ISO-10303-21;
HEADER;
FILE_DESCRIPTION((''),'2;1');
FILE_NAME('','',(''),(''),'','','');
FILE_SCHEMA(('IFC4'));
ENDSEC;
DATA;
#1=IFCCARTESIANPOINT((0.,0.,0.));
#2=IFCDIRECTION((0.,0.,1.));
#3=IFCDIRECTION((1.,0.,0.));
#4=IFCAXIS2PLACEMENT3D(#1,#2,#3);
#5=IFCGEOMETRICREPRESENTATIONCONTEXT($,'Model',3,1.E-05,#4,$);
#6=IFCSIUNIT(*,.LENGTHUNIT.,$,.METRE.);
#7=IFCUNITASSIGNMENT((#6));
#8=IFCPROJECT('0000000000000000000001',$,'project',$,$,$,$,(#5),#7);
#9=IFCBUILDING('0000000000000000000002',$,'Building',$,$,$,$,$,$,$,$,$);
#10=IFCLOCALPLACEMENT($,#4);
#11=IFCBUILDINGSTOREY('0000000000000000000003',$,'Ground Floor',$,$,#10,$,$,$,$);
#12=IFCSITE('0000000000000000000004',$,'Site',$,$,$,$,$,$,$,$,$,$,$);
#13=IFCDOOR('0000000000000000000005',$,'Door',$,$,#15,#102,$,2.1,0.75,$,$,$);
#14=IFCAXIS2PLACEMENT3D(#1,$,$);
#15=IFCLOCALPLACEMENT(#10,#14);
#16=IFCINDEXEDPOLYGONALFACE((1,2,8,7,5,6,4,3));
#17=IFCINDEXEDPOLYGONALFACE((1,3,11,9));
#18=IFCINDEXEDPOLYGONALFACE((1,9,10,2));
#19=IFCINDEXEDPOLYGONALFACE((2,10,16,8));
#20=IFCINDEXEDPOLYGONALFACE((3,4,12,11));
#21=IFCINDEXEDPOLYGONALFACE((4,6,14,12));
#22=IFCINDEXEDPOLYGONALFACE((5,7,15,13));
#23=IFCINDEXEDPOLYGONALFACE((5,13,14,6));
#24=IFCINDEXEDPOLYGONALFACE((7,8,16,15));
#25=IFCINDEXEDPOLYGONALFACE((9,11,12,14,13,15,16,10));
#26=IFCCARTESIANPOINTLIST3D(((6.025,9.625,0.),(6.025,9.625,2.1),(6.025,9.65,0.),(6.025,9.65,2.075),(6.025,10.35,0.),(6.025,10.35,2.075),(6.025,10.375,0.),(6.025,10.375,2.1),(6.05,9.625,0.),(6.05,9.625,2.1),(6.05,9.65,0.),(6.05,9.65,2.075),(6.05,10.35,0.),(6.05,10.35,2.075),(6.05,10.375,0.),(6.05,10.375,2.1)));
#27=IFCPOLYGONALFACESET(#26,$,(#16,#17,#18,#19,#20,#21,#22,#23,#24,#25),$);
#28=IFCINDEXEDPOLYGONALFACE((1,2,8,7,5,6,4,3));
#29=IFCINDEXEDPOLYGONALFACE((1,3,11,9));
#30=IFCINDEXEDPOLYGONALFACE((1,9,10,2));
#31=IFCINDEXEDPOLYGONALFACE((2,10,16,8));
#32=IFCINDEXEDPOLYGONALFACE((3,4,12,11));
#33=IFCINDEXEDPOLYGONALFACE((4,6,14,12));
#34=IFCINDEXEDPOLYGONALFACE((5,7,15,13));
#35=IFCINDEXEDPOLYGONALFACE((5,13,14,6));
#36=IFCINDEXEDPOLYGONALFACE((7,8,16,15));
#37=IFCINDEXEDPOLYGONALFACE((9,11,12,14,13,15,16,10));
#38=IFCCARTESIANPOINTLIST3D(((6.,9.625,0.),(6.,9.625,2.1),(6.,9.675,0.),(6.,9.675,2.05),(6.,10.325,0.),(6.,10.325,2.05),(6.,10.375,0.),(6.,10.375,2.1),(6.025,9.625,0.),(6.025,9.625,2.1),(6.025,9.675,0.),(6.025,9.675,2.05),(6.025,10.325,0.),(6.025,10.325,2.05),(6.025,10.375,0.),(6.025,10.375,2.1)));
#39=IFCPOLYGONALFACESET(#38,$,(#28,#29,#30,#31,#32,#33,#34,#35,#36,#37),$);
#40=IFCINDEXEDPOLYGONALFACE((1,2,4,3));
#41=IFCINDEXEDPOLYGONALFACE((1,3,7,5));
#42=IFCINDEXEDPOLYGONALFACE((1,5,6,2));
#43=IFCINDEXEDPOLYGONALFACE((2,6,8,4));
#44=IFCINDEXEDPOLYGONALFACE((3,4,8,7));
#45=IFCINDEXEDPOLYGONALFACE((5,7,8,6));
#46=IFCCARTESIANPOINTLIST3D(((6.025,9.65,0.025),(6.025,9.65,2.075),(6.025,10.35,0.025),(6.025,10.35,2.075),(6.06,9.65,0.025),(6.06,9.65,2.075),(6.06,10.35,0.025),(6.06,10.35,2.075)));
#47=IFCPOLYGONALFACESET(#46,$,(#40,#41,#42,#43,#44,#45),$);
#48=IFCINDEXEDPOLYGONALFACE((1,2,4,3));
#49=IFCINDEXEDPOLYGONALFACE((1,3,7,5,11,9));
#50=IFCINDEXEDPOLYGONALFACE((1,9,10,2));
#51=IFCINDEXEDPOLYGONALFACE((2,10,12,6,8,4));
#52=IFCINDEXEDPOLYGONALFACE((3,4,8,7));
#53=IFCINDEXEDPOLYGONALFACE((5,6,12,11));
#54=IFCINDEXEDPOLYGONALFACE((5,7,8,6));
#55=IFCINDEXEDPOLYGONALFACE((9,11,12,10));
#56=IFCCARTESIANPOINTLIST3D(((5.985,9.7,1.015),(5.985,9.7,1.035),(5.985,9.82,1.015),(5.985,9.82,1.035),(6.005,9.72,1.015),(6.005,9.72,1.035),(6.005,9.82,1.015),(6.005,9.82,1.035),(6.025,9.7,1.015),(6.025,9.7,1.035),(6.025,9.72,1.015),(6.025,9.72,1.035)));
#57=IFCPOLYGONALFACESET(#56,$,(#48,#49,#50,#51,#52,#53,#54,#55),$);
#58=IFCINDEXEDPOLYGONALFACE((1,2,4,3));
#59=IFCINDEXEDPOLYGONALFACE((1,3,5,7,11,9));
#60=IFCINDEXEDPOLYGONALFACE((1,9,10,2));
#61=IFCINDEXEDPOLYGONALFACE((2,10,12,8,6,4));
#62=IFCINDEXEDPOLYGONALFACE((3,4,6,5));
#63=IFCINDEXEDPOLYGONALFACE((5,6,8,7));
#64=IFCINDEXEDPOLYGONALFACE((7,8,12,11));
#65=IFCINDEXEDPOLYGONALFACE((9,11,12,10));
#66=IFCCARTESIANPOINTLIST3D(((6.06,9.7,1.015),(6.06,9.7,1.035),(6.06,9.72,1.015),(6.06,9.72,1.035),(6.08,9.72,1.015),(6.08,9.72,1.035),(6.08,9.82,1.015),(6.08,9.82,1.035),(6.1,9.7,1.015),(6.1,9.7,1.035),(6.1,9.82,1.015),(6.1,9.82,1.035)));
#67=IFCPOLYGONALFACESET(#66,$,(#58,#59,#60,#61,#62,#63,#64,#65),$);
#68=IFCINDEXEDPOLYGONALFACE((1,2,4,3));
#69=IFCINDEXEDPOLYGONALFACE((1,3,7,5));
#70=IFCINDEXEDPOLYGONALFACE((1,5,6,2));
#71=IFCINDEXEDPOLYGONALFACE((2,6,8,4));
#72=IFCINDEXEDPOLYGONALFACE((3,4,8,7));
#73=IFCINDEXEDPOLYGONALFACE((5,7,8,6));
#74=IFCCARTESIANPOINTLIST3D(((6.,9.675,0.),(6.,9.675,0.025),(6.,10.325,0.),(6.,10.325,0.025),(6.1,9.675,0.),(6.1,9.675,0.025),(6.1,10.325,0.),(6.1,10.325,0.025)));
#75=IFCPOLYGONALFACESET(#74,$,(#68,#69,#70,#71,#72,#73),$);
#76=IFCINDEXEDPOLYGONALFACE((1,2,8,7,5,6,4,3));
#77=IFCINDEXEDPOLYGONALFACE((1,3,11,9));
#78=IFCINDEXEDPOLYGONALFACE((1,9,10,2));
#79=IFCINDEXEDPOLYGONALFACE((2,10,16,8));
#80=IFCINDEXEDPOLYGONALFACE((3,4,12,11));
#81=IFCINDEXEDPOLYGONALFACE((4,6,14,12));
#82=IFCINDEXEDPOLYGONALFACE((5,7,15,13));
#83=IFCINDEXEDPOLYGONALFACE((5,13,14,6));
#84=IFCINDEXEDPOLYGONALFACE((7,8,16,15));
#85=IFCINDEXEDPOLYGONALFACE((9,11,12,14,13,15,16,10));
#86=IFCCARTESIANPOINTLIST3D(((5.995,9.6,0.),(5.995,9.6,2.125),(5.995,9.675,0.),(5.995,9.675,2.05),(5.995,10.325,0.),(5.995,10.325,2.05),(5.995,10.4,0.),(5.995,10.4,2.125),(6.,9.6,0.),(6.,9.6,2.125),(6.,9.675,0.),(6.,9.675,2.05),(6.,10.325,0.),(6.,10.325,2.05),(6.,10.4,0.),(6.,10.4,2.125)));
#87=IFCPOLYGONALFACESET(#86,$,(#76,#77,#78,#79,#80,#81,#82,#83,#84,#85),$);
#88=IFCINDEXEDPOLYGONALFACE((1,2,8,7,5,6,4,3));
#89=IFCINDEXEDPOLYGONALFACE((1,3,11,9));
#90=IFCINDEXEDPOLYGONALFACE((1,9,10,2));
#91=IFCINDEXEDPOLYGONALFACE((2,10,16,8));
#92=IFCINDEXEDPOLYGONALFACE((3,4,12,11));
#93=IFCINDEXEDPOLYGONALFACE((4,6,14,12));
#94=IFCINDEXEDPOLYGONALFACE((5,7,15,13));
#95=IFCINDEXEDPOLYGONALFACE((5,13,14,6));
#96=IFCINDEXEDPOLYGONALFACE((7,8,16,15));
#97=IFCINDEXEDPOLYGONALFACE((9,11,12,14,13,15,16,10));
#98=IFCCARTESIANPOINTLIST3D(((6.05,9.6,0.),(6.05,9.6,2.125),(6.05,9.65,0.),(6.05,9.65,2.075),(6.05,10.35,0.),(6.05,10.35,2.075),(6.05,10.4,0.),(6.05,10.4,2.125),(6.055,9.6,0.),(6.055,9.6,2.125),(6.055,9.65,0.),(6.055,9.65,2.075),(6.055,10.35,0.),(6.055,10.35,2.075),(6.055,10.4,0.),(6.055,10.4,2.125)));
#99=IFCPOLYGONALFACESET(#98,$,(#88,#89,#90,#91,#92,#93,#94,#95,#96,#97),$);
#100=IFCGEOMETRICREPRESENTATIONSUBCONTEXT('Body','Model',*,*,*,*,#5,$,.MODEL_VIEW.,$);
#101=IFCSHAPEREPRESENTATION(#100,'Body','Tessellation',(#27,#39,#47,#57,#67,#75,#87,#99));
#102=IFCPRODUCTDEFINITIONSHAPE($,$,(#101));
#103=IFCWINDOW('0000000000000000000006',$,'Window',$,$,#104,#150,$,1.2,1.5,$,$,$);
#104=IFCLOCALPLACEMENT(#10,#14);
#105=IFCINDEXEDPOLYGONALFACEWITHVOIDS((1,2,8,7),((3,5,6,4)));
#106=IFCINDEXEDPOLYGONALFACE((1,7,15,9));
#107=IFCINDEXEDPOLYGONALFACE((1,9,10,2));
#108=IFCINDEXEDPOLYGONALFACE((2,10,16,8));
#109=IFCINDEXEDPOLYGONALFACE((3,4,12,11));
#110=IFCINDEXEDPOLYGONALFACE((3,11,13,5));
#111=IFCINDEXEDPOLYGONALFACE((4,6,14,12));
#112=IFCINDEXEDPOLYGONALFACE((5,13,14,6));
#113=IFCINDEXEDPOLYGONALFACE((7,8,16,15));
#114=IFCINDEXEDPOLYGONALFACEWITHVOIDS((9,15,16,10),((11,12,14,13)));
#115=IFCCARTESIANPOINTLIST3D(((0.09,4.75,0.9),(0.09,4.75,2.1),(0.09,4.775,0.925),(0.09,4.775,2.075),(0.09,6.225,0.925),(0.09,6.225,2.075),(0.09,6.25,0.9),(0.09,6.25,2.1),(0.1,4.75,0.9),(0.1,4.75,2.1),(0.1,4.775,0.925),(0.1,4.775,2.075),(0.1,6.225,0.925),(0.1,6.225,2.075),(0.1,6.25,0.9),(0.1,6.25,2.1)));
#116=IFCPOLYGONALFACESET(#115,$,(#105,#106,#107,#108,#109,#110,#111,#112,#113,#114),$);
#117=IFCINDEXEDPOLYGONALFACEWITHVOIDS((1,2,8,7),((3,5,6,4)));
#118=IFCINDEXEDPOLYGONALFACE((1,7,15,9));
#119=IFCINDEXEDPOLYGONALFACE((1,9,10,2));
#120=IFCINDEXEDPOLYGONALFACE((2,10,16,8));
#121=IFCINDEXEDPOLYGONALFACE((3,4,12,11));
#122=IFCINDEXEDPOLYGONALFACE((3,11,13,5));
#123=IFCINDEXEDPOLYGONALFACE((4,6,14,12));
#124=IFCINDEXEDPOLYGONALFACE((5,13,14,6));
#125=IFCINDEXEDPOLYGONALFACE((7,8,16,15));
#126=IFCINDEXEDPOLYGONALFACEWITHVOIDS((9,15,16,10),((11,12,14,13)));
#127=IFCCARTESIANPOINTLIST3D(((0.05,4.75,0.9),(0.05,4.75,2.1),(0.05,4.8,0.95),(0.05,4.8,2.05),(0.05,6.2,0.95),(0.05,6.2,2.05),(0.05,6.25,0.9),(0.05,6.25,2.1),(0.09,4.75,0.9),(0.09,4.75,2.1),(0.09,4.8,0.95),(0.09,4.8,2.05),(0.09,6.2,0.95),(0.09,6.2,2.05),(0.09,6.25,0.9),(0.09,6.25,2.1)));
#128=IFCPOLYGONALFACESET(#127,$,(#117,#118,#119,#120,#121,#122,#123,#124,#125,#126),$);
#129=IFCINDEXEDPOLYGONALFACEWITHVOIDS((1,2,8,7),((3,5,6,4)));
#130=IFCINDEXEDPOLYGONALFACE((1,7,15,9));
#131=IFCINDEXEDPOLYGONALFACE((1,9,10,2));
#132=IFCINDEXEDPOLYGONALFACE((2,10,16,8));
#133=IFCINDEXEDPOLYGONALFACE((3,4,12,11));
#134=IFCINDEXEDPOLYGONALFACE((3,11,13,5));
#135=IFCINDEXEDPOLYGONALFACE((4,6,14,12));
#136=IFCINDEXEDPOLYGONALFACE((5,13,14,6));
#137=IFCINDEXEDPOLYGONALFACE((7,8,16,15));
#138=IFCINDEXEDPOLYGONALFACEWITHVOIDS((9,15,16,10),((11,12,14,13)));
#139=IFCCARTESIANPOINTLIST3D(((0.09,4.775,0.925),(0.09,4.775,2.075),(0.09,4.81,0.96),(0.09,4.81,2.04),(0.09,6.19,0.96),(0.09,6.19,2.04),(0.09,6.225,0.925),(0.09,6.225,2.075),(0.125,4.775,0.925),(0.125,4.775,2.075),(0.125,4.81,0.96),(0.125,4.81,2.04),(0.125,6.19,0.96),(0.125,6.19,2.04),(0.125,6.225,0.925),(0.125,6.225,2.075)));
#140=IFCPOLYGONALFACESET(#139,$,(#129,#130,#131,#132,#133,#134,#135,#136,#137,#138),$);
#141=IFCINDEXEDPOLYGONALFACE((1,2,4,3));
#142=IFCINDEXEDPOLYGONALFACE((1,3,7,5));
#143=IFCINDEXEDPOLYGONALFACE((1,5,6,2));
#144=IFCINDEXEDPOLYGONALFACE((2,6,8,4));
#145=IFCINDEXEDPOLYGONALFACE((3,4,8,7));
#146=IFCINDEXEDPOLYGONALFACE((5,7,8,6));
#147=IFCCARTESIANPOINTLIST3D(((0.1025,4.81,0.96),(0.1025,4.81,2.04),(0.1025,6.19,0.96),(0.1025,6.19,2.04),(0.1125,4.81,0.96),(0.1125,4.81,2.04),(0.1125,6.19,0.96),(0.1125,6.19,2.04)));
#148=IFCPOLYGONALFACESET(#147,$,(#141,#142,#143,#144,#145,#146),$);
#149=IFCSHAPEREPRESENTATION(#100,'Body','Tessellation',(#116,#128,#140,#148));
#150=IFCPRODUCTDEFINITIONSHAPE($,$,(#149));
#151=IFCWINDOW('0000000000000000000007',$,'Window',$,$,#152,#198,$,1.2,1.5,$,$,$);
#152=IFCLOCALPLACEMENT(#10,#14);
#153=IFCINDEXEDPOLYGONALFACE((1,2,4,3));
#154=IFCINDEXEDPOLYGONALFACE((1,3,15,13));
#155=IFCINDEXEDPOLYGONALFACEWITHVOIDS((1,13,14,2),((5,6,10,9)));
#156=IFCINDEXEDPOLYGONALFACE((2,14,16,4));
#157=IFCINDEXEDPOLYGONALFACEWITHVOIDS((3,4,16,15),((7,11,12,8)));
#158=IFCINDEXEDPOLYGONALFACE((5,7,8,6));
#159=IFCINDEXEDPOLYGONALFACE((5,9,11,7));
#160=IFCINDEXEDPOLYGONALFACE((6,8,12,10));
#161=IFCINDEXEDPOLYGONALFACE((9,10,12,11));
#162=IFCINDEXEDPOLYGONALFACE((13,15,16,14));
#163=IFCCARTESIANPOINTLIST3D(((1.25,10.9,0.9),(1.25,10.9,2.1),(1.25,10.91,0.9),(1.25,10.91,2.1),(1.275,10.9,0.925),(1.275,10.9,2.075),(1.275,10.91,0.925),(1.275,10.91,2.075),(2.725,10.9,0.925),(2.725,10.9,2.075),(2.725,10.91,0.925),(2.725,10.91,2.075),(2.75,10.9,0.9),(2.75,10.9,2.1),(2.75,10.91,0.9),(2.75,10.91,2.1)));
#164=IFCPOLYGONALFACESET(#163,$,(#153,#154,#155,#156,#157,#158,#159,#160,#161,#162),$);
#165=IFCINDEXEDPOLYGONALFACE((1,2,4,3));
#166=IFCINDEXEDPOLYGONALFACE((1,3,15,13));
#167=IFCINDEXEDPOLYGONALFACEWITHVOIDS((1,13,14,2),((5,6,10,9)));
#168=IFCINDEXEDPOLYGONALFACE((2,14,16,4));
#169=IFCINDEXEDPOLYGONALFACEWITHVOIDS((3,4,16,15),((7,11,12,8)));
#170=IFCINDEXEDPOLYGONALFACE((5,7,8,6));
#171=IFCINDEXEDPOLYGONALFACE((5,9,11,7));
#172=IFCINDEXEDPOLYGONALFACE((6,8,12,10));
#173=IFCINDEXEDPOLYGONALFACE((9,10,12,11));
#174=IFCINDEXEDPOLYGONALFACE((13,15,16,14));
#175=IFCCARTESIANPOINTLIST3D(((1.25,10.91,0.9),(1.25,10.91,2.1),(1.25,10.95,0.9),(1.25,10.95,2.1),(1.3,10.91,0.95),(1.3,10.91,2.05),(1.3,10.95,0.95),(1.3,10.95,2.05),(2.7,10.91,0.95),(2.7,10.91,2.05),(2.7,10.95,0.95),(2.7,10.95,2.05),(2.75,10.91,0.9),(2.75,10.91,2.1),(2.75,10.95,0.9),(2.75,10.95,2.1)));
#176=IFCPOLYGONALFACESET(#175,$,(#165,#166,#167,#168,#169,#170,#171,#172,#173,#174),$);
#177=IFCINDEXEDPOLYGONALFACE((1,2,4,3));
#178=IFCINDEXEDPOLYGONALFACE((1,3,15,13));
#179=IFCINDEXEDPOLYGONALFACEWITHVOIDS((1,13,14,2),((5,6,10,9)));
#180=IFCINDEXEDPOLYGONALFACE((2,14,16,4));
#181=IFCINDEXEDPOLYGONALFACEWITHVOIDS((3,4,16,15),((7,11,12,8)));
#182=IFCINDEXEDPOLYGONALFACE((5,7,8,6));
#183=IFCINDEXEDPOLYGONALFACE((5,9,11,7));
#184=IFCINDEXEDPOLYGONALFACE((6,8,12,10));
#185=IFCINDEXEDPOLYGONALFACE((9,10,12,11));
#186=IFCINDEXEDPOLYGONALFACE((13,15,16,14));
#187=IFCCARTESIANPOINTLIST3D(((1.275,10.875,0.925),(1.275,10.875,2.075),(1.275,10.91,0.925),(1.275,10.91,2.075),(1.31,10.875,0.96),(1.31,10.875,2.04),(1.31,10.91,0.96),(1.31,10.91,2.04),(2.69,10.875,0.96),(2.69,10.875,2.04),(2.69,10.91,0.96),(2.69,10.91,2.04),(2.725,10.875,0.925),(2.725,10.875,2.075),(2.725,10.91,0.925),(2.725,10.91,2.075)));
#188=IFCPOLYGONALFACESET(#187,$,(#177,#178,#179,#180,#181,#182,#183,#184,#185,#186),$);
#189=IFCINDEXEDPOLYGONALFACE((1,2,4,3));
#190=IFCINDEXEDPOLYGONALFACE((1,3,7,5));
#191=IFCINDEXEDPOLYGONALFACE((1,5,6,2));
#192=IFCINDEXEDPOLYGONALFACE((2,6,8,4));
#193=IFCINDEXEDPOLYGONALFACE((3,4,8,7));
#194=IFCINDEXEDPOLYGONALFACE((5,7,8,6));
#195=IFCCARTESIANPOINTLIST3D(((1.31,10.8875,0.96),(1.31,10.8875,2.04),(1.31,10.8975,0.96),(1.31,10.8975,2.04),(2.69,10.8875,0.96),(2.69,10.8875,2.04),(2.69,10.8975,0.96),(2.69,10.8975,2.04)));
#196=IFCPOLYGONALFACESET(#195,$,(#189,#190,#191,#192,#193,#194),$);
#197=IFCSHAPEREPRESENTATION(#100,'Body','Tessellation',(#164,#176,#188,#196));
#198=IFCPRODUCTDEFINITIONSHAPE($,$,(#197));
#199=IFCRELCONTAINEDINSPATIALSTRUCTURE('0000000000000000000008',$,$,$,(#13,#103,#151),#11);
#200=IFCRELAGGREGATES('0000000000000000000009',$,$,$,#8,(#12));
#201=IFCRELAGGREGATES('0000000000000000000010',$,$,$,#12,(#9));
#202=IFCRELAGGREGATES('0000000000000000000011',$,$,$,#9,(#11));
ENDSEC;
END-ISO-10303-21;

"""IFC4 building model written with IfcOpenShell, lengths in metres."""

from ifc_helpers import new_model, si_unit, frame, origin_with_axes, place, context, subcontext, project, spatial, line, indexed_curve, outline, extrude, element, save


model = new_model("IFC4")

# Units and contexts
model_context = context("Model", 3, precision=1e-05, world=origin_with_axes())
body_context = subcontext(model_context, "Body", "Model", "MODEL_VIEW")
ifc_project = project(units=[si_unit("LENGTHUNIT", "METRE")], contexts=[model_context])

# Site, building, storey
site = spatial("IfcSite", under=ifc_project, Name="Site")
building = spatial("IfcBuilding", under=site, Name="Building")
storey_placement = place(None, origin_with_axes())
storey = spatial("IfcBuildingStorey", under=building, at=storey_placement, Name="Ground Floor")

# Door
door_1_placement = place(storey_placement, frame((6.0, 10.375, 0.0), z_axis=(0.0, 0.0, 1.0), x_axis=(0.0, -1.0, 0.0)))
element("IfcDoor", 1, at=door_1_placement, inside=storey, Name="Door", OverallHeight=2.1, OverallWidth=0.75, context=body_context, shape_type="SweptSolid", body=[
    extrude(outline(indexed_curve([(0.0, 0.0), (0.0, 2.1), (0.75, 2.1), (0.75, 0.0), (0.725, 0.0), (0.725, 2.075), (0.025, 2.075), (0.025, 0.0)], segments=[line(1, 2, 3, 4, 5, 6, 7, 8, 1)])), frame((0.0, 0.025, 0.0), z_axis=(0.0, -1.0, 0.0), x_axis=(1.0, 0.0, 0.0)), (0.0, 0.0, -1.0), 0.025),
    extrude(outline(indexed_curve([(0.0, 0.0), (0.0, 2.1), (0.75, 2.1), (0.75, 0.0), (0.7, 0.0), (0.7, 2.05), (0.05, 2.05), (0.05, 0.0)], segments=[line(1, 2, 3, 4, 5, 6, 7, 8, 1)])), frame((0.0, 0.0, 0.0), z_axis=(0.0, -1.0, 0.0), x_axis=(1.0, 0.0, 0.0)), (0.0, 0.0, -1.0), 0.025),
    extrude(outline(indexed_curve([(0.0, 0.0), (0.7, 0.0), (0.7, 0.035), (0.0, 0.035)], segments=[line(1, 2, 3, 4, 1)])), frame((0.025, 0.025, 0.025), z_axis=(0.0, 0.0, 1.0), x_axis=(1.0, 0.0, 0.0)), (0.0, 0.0, 1.0), 2.05),
    extrude(outline(indexed_curve([(0.0, 0.0), (0.0, -0.04), (-0.12, -0.04), (-0.12, -0.02), (-0.02, -0.02), (-0.02, 0.0)], segments=[line(1, 2, 3, 4, 5, 6, 1)])), frame((0.675, 0.025, 1.015), z_axis=(0.0, 0.0, 1.0), x_axis=(1.0, 0.0, 0.0)), (0.0, 0.0, 1.0), 0.02),
    extrude(outline(indexed_curve([(0.0, 0.0), (0.0, 0.04), (-0.12, 0.04), (-0.12, 0.02), (-0.02, 0.02), (-0.02, 0.0)], segments=[line(1, 2, 3, 4, 5, 6, 1)])), frame((0.675, 0.06, 1.015), z_axis=(0.0, 0.0, 1.0), x_axis=(1.0, 0.0, 0.0)), (0.0, 0.0, 1.0), 0.02),
    extrude(outline(indexed_curve([(0.0, 0.0), (0.65, 0.0), (0.65, 0.1), (0.0, 0.1)], segments=[line(1, 2, 3, 4, 1)])), frame((0.05, 0.0, 0.0), z_axis=(0.0, 0.0, 1.0), x_axis=(1.0, 0.0, 0.0)), (0.0, 0.0, 1.0), 0.025),
    extrude(outline(indexed_curve([(0.0, 0.0), (0.0, 2.125), (0.8, 2.125), (0.8, 0.0), (0.725, 0.0), (0.725, 2.05), (0.075, 2.05), (0.075, 0.0)], segments=[line(1, 2, 3, 4, 5, 6, 7, 8, 1)])), frame((-0.025, -0.005, 0.0), z_axis=(0.0, -1.0, 0.0), x_axis=(1.0, 0.0, 0.0)), (0.0, 0.0, -1.0), 0.005),
    extrude(outline(indexed_curve([(0.0, 0.0), (0.0, 2.125), (0.8, 2.125), (0.8, 0.0), (0.75, 0.0), (0.75, 2.075), (0.05, 2.075), (0.05, 0.0)], segments=[line(1, 2, 3, 4, 5, 6, 7, 8, 1)])), frame((-0.025, 0.05, 0.0), z_axis=(0.0, -1.0, 0.0), x_axis=(1.0, 0.0, 0.0)), (0.0, 0.0, -1.0), 0.005),
])

# Windows
for number, where, z_axis, x_axis, name in (
    (2, (0.0, 6.25, 0.9), (0.0, 0.0, 1.0), (0.0, -1.0, 0.0), "Window"),
    (3, (2.75, 11.0, 0.9), (0.0, 0.0, 1.0), (-1.0, 0.0, 0.0), "Window"),
):
    element("IfcWindow", number, at=place(storey_placement, frame(where, z_axis=z_axis, x_axis=x_axis)), inside=storey, Name=name, OverallHeight=1.2, OverallWidth=1.5, context=body_context, shape_type="SweptSolid", body=[
        extrude(outline(indexed_curve([(0.0, 0.0), (1.5, 0.0), (1.5, 1.2), (0.0, 1.2)], segments=[line(1, 2, 3, 4, 1)]), holes=[indexed_curve([(0.025, 0.025), (1.475, 0.025), (1.475, 1.175), (0.025, 1.175)], segments=[line(1, 2, 3, 4, 1)])]), frame((0.0, 0.09, 0.0), z_axis=(0.0, -1.0, 0.0), x_axis=(1.0, 0.0, 0.0)), (0.0, 0.0, -1.0), 0.01),
        extrude(outline(indexed_curve([(0.0, 0.0), (1.5, 0.0), (1.5, 1.2), (0.0, 1.2)], segments=[line(1, 2, 3, 4, 1)]), holes=[indexed_curve([(0.05, 0.05), (1.45, 0.05), (1.45, 1.15), (0.05, 1.15)], segments=[line(1, 2, 3, 4, 1)])]), frame((0.0, 0.05, 0.0), z_axis=(0.0, -1.0, 0.0), x_axis=(1.0, 0.0, 0.0)), (0.0, 0.0, -1.0), 0.04),
        extrude(outline(indexed_curve([(0.0, 0.0), (1.45, 0.0), (1.45, 1.15), (0.0, 1.15)], segments=[line(1, 2, 3, 4, 1)]), holes=[indexed_curve([(0.035, 0.035), (1.415, 0.035), (1.415, 1.115), (0.035, 1.115)], segments=[line(1, 2, 3, 4, 1)])]), frame((0.025, 0.09, 0.025), z_axis=(0.0, -1.0, 0.0), x_axis=(1.0, 0.0, 0.0)), (0.0, 0.0, -1.0), 0.035),
        extrude(outline(indexed_curve([(0.035, 0.035), (1.415, 0.035), (1.415, 1.115), (0.035, 1.115)], segments=[line(1, 2, 3, 4, 1)])), frame((0.025, 0.1025, 0.025), z_axis=(0.0, -1.0, 0.0), x_axis=(1.0, 0.0, 0.0)), (0.0, 0.0, -1.0), 0.01),
    ])

save(model, "model.ifc")
